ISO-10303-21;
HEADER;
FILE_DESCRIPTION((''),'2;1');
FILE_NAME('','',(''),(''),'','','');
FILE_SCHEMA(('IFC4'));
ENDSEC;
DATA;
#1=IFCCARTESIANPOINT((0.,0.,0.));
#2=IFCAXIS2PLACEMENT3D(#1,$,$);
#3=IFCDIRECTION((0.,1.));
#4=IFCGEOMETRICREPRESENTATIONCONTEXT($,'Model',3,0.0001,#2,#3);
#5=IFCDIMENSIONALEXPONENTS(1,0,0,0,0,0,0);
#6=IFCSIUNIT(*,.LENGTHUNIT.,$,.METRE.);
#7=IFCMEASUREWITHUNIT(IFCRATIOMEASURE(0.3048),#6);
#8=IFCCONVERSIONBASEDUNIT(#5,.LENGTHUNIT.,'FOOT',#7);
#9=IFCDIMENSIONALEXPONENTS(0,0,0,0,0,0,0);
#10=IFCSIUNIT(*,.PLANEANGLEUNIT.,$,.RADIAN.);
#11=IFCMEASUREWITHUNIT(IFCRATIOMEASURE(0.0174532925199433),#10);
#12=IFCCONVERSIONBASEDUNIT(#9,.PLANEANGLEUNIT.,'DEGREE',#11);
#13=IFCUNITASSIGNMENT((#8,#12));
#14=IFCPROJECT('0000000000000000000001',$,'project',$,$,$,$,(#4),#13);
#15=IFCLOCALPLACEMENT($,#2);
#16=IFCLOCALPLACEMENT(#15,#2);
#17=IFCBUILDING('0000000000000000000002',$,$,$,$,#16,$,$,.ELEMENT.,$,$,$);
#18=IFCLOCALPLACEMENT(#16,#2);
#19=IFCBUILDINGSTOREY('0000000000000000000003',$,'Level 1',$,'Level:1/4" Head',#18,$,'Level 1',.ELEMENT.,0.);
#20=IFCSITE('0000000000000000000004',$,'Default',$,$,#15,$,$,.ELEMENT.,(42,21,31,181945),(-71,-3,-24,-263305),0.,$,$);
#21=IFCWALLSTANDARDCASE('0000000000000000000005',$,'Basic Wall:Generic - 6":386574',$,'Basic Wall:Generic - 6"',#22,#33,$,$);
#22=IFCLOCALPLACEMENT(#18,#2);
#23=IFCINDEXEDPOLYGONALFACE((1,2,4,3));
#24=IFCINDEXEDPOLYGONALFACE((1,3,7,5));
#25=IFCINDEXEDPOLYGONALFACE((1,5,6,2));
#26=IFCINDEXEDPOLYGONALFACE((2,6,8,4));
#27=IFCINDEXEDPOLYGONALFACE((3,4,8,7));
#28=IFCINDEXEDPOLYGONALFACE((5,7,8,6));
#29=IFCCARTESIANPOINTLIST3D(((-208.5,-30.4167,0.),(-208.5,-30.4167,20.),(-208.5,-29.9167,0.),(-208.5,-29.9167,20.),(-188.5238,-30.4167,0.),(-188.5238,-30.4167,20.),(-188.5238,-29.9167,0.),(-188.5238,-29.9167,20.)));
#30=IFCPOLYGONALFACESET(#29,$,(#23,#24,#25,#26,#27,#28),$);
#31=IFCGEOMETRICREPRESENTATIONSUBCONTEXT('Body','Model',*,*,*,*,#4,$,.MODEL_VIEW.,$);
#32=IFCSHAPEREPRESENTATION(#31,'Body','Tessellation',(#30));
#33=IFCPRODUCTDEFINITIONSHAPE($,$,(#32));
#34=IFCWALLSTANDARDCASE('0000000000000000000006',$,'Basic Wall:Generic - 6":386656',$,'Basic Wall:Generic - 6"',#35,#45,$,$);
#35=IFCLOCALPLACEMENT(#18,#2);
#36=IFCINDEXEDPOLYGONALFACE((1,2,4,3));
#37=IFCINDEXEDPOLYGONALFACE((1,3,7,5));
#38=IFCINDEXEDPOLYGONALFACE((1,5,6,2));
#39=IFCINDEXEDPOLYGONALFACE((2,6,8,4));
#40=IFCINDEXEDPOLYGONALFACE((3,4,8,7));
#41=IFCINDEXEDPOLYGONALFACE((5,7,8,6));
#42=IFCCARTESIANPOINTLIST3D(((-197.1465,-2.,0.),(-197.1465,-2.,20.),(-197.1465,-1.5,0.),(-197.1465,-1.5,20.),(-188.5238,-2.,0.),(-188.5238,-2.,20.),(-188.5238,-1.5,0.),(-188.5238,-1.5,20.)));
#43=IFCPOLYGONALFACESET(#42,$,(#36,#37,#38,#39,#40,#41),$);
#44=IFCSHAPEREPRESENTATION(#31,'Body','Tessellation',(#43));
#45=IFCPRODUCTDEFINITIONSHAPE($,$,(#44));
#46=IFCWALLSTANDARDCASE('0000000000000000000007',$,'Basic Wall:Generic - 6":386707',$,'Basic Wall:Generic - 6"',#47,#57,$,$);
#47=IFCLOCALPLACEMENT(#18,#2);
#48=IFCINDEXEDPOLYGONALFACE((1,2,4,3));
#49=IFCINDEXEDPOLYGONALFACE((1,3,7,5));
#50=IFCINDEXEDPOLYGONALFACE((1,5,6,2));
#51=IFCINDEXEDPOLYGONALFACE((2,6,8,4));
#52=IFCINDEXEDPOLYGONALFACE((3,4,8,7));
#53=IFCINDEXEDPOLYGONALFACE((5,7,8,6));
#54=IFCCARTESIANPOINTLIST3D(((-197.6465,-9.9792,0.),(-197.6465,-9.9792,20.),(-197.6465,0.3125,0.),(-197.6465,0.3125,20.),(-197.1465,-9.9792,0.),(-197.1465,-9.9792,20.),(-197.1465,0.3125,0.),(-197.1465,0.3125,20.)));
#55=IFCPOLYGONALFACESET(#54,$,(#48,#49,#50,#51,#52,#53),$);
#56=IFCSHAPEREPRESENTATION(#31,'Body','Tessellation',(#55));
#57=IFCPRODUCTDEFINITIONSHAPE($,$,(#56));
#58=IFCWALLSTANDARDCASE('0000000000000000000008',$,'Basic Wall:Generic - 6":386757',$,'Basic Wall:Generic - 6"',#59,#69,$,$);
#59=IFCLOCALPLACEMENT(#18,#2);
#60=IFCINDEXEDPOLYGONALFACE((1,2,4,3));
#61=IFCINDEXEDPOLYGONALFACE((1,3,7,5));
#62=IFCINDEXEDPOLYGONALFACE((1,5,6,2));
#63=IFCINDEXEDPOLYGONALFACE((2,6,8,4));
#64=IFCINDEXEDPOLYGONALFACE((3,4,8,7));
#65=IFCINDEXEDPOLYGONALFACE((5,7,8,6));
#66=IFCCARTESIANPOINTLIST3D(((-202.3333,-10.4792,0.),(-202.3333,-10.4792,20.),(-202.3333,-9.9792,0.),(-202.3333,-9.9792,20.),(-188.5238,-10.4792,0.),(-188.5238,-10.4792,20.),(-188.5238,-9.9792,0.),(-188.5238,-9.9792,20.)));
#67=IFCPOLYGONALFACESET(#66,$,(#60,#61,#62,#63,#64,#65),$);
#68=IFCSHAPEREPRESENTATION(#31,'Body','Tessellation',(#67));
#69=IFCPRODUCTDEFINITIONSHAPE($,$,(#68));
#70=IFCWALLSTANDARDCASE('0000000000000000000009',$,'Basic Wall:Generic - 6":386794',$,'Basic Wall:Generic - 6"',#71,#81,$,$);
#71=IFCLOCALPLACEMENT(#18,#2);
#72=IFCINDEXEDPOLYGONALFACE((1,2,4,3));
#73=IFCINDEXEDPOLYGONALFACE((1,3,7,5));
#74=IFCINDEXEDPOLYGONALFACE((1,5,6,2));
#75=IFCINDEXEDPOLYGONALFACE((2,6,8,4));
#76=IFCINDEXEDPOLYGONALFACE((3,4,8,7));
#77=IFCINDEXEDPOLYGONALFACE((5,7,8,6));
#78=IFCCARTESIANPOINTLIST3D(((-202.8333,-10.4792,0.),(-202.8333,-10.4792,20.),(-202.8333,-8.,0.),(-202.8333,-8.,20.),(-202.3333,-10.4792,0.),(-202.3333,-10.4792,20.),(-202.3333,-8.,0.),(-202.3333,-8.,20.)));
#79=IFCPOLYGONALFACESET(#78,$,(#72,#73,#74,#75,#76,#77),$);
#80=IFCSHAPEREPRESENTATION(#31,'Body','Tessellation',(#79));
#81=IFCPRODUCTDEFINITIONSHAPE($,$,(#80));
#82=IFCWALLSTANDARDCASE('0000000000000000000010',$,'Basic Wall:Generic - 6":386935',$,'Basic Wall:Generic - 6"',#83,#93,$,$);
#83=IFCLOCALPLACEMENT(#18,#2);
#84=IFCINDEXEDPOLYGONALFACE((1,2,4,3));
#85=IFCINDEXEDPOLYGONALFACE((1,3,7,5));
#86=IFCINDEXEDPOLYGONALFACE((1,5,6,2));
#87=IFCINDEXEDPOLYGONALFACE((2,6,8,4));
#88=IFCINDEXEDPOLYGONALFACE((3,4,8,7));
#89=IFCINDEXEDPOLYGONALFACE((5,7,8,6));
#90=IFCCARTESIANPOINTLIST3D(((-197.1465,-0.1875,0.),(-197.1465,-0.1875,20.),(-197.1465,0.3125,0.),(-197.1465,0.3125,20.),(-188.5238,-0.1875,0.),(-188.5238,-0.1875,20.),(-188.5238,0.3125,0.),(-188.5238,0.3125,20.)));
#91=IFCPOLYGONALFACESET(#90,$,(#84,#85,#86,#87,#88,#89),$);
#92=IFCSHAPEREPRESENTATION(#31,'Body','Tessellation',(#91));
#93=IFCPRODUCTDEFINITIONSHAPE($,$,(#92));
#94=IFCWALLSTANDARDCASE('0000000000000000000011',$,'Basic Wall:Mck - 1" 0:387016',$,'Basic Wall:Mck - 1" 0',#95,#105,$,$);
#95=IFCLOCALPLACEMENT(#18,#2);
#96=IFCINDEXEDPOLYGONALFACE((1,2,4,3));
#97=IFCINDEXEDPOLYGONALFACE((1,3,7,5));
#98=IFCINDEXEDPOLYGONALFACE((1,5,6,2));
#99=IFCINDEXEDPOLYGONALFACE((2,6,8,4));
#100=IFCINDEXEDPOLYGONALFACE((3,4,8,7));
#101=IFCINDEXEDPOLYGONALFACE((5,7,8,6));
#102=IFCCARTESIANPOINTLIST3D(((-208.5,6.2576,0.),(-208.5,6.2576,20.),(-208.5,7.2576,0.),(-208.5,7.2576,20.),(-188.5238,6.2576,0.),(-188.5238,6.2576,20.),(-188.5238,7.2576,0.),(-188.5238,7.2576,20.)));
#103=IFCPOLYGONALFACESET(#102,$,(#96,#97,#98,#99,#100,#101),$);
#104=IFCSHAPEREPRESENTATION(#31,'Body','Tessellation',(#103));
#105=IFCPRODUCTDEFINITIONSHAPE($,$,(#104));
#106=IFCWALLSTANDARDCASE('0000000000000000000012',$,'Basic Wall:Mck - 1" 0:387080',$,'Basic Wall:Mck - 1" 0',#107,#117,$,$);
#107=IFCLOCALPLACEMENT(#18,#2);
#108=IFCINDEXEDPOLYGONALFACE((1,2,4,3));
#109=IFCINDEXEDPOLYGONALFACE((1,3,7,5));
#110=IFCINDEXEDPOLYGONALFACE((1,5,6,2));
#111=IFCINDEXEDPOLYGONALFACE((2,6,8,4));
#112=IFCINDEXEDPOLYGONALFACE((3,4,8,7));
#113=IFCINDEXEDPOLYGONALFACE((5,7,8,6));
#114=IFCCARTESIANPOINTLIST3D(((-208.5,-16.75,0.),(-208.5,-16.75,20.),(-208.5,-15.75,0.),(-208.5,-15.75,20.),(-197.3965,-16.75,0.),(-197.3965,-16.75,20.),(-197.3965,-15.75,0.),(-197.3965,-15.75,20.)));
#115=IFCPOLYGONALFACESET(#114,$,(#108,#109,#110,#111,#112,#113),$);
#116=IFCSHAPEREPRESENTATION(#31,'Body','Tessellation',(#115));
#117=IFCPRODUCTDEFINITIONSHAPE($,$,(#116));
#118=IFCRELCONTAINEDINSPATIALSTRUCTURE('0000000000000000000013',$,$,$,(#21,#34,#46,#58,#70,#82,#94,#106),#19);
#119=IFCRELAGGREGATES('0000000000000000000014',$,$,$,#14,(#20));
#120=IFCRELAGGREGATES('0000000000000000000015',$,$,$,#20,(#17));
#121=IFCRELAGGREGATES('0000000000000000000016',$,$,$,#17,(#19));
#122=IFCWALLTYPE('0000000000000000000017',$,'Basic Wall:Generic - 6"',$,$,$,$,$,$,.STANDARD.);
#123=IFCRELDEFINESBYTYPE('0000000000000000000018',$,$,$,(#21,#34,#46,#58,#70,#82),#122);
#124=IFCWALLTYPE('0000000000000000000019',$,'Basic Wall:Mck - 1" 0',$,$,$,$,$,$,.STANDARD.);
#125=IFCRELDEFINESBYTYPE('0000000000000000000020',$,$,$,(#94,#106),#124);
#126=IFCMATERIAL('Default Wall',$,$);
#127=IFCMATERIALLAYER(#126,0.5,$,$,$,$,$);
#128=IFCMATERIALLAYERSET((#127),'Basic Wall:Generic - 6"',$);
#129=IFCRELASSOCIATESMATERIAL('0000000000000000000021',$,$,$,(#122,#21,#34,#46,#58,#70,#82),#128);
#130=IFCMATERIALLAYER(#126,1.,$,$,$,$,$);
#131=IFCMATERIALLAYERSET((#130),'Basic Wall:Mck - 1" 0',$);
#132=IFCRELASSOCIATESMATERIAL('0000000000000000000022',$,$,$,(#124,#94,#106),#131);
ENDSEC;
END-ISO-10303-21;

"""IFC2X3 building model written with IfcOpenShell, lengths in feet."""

from ifc_helpers import new_model, entity, si_unit, converted_unit, direction, frame, frame_2d, origin, place, context, subcontext, project, spatial, rectangle, extrude, material, layer, layer_set, layer_usage, type_object, element, save


model = new_model("IFC2X3")

# Units and contexts
model_context = context("Model", 3, precision=0.0001, world=origin(), true_north=direction((0.0, 1.0)))
body_context = subcontext(model_context, "Body", "Model", "MODEL_VIEW")
ifc_project = project(units=[converted_unit("LENGTHUNIT", "FOOT", entity("IfcRatioMeasure", 0.3048), si_unit("LENGTHUNIT", "METRE"), dimensions=[1, 0, 0, 0, 0, 0, 0]), converted_unit("PLANEANGLEUNIT", "DEGREE", entity("IfcRatioMeasure", 0.0174532925199433), si_unit("PLANEANGLEUNIT", "RADIAN"), dimensions=[0, 0, 0, 0, 0, 0, 0])], contexts=[model_context])

# Site, building, storey
site_placement = place(None, origin())
site = spatial("IfcSite", under=ifc_project, at=site_placement, Name="Default", CompositionType="ELEMENT", RefLatitude=(42, 21, 31, 181945), RefLongitude=(-71, -3, -24, -263305), RefElevation=0.0)
building_placement = place(site_placement, origin())
building = spatial("IfcBuilding", under=site, at=building_placement, CompositionType="ELEMENT")
storey_placement = place(building_placement, origin())
storey = spatial("IfcBuildingStorey", under=building, at=storey_placement, Name="Level 1", ObjectType="Level:1/4\" Head", LongName="Level 1", CompositionType="ELEMENT", Elevation=0.0)

# Walls
ifc_material = material(Name="Default Wall")
ifc_layer_1 = layer(ifc_material, 0.5)
ifc_layer_set_1 = layer_set([ifc_layer_1], Name="Basic Wall:Generic - 6\"")
wall_type_1 = type_object("IfcWallType", Name="Basic Wall:Generic - 6\"", PredefinedType="STANDARD", material=ifc_layer_set_1)
ifc_layer_usage_1 = layer_usage(ifc_layer_set_1, "AXIS2", "NEGATIVE", 0.25)
wall_1_placement = place(storey_placement, frame((-188.5238, -30.1667, 0.0), z_axis=(0.0, 0.0, 1.0), x_axis=(-1.0, 0.0, 0.0)))
element("IfcWallStandardCase", 1, at=wall_1_placement, inside=storey, type_object=wall_type_1, material=ifc_layer_usage_1, Name="Basic Wall:Generic - 6\":386574", ObjectType="Basic Wall:Generic - 6\"", context=body_context, shape_type="SweptSolid", body=[
    extrude(rectangle(XDim=19.9762, YDim=0.5, at=frame_2d((9.9881, 0.0), x_axis=(-1.0, 0.0))), origin(), (0.0, 0.0, 1.0), 20.0),
])
ifc_layer_usage_2 = layer_usage(ifc_layer_set_1, "AXIS2", "NEGATIVE", 0.25)
wall_2_placement = place(storey_placement, frame((-188.5238, -1.75, 0.0), z_axis=(0.0, 0.0, 1.0), x_axis=(-1.0, 0.0, 0.0)))
element("IfcWallStandardCase", 2, at=wall_2_placement, inside=storey, type_object=wall_type_1, material=ifc_layer_usage_2, Name="Basic Wall:Generic - 6\":386656", ObjectType="Basic Wall:Generic - 6\"", context=body_context, shape_type="SweptSolid", body=[
    extrude(rectangle(XDim=8.6227, YDim=0.5, at=frame_2d((4.3114, 0.0), x_axis=(-1.0, 0.0))), origin(), (0.0, 0.0, 1.0), 20.0),
])
ifc_layer_usage_3 = layer_usage(ifc_layer_set_1, "AXIS2", "NEGATIVE", 0.25)
wall_3_placement = place(storey_placement, frame((-197.3965, 0.3125, 0.0), z_axis=(0.0, 0.0, 1.0), x_axis=(0.0, -1.0, 0.0)))
element("IfcWallStandardCase", 3, at=wall_3_placement, inside=storey, type_object=wall_type_1, material=ifc_layer_usage_3, Name="Basic Wall:Generic - 6\":386707", ObjectType="Basic Wall:Generic - 6\"", context=body_context, shape_type="SweptSolid", body=[
    extrude(rectangle(XDim=10.2917, YDim=0.5, at=frame_2d((5.1458, 0.0), x_axis=(-1.0, 0.0))), origin(), (0.0, 0.0, 1.0), 20.0),
])
ifc_layer_usage_4 = layer_usage(ifc_layer_set_1, "AXIS2", "NEGATIVE", 0.25)
wall_4_placement = place(storey_placement, frame((-202.3333, -10.2292, 0.0)))
element("IfcWallStandardCase", 4, at=wall_4_placement, inside=storey, type_object=wall_type_1, material=ifc_layer_usage_4, Name="Basic Wall:Generic - 6\":386757", ObjectType="Basic Wall:Generic - 6\"", context=body_context, shape_type="SweptSolid", body=[
    extrude(rectangle(XDim=13.8096, YDim=0.5, at=frame_2d((6.9048, 0.0), x_axis=(-1.0, 0.0))), origin(), (0.0, 0.0, 1.0), 20.0),
])
ifc_layer_usage_5 = layer_usage(ifc_layer_set_1, "AXIS2", "NEGATIVE", 0.25)
wall_5_placement = place(storey_placement, frame((-202.5833, -8.0, 0.0), z_axis=(0.0, 0.0, 1.0), x_axis=(0.0, -1.0, 0.0)))
element("IfcWallStandardCase", 5, at=wall_5_placement, inside=storey, type_object=wall_type_1, material=ifc_layer_usage_5, Name="Basic Wall:Generic - 6\":386794", ObjectType="Basic Wall:Generic - 6\"", context=body_context, shape_type="SweptSolid", body=[
    extrude(rectangle(XDim=2.4792, YDim=0.5, at=frame_2d((1.2396, 0.0), x_axis=(-1.0, 0.0))), origin(), (0.0, 0.0, 1.0), 20.0),
])
ifc_layer_usage_6 = layer_usage(ifc_layer_set_1, "AXIS2", "NEGATIVE", 0.25)
wall_6_placement = place(storey_placement, frame((-197.1465, 0.0625, 0.0)))
element("IfcWallStandardCase", 6, at=wall_6_placement, inside=storey, type_object=wall_type_1, material=ifc_layer_usage_6, Name="Basic Wall:Generic - 6\":386935", ObjectType="Basic Wall:Generic - 6\"", context=body_context, shape_type="SweptSolid", body=[
    extrude(rectangle(XDim=8.6227, YDim=0.5, at=frame_2d((4.3114, 0.0), x_axis=(-1.0, 0.0))), origin(), (0.0, 0.0, 1.0), 20.0),
])
ifc_layer_2 = layer(ifc_material, 1.0)
ifc_layer_set_2 = layer_set([ifc_layer_2], Name="Basic Wall:Mck - 1\" 0")
ifc_layer_usage_7 = layer_usage(ifc_layer_set_2, "AXIS2", "NEGATIVE", 0.5)
wall_type_2 = type_object("IfcWallType", Name="Basic Wall:Mck - 1\" 0", PredefinedType="STANDARD", material=ifc_layer_set_2)
wall_7_placement = place(storey_placement, frame((-208.5, 6.7576, 0.0)))
element("IfcWallStandardCase", 7, at=wall_7_placement, inside=storey, type_object=wall_type_2, material=ifc_layer_usage_7, Name="Basic Wall:Mck - 1\" 0:387016", ObjectType="Basic Wall:Mck - 1\" 0", context=body_context, shape_type="SweptSolid", body=[
    extrude(rectangle(XDim=19.9762, YDim=1.0, at=frame_2d((9.9881, 0.0), x_axis=(-1.0, 0.0))), origin(), (0.0, 0.0, 1.0), 20.0),
])
ifc_layer_usage_8 = layer_usage(ifc_layer_set_2, "AXIS2", "NEGATIVE", 0.5)
wall_8_placement = place(storey_placement, frame((-208.5, -16.25, 0.0)))
element("IfcWallStandardCase", 8, at=wall_8_placement, inside=storey, type_object=wall_type_2, material=ifc_layer_usage_8, Name="Basic Wall:Mck - 1\" 0:387080", ObjectType="Basic Wall:Mck - 1\" 0", context=body_context, shape_type="SweptSolid", body=[
    extrude(rectangle(XDim=11.1035, YDim=1.0, at=frame_2d((5.5518, 0.0), x_axis=(-1.0, 0.0))), origin(), (0.0, 0.0, 1.0), 20.0),
])

save(model, "model.ifc")
